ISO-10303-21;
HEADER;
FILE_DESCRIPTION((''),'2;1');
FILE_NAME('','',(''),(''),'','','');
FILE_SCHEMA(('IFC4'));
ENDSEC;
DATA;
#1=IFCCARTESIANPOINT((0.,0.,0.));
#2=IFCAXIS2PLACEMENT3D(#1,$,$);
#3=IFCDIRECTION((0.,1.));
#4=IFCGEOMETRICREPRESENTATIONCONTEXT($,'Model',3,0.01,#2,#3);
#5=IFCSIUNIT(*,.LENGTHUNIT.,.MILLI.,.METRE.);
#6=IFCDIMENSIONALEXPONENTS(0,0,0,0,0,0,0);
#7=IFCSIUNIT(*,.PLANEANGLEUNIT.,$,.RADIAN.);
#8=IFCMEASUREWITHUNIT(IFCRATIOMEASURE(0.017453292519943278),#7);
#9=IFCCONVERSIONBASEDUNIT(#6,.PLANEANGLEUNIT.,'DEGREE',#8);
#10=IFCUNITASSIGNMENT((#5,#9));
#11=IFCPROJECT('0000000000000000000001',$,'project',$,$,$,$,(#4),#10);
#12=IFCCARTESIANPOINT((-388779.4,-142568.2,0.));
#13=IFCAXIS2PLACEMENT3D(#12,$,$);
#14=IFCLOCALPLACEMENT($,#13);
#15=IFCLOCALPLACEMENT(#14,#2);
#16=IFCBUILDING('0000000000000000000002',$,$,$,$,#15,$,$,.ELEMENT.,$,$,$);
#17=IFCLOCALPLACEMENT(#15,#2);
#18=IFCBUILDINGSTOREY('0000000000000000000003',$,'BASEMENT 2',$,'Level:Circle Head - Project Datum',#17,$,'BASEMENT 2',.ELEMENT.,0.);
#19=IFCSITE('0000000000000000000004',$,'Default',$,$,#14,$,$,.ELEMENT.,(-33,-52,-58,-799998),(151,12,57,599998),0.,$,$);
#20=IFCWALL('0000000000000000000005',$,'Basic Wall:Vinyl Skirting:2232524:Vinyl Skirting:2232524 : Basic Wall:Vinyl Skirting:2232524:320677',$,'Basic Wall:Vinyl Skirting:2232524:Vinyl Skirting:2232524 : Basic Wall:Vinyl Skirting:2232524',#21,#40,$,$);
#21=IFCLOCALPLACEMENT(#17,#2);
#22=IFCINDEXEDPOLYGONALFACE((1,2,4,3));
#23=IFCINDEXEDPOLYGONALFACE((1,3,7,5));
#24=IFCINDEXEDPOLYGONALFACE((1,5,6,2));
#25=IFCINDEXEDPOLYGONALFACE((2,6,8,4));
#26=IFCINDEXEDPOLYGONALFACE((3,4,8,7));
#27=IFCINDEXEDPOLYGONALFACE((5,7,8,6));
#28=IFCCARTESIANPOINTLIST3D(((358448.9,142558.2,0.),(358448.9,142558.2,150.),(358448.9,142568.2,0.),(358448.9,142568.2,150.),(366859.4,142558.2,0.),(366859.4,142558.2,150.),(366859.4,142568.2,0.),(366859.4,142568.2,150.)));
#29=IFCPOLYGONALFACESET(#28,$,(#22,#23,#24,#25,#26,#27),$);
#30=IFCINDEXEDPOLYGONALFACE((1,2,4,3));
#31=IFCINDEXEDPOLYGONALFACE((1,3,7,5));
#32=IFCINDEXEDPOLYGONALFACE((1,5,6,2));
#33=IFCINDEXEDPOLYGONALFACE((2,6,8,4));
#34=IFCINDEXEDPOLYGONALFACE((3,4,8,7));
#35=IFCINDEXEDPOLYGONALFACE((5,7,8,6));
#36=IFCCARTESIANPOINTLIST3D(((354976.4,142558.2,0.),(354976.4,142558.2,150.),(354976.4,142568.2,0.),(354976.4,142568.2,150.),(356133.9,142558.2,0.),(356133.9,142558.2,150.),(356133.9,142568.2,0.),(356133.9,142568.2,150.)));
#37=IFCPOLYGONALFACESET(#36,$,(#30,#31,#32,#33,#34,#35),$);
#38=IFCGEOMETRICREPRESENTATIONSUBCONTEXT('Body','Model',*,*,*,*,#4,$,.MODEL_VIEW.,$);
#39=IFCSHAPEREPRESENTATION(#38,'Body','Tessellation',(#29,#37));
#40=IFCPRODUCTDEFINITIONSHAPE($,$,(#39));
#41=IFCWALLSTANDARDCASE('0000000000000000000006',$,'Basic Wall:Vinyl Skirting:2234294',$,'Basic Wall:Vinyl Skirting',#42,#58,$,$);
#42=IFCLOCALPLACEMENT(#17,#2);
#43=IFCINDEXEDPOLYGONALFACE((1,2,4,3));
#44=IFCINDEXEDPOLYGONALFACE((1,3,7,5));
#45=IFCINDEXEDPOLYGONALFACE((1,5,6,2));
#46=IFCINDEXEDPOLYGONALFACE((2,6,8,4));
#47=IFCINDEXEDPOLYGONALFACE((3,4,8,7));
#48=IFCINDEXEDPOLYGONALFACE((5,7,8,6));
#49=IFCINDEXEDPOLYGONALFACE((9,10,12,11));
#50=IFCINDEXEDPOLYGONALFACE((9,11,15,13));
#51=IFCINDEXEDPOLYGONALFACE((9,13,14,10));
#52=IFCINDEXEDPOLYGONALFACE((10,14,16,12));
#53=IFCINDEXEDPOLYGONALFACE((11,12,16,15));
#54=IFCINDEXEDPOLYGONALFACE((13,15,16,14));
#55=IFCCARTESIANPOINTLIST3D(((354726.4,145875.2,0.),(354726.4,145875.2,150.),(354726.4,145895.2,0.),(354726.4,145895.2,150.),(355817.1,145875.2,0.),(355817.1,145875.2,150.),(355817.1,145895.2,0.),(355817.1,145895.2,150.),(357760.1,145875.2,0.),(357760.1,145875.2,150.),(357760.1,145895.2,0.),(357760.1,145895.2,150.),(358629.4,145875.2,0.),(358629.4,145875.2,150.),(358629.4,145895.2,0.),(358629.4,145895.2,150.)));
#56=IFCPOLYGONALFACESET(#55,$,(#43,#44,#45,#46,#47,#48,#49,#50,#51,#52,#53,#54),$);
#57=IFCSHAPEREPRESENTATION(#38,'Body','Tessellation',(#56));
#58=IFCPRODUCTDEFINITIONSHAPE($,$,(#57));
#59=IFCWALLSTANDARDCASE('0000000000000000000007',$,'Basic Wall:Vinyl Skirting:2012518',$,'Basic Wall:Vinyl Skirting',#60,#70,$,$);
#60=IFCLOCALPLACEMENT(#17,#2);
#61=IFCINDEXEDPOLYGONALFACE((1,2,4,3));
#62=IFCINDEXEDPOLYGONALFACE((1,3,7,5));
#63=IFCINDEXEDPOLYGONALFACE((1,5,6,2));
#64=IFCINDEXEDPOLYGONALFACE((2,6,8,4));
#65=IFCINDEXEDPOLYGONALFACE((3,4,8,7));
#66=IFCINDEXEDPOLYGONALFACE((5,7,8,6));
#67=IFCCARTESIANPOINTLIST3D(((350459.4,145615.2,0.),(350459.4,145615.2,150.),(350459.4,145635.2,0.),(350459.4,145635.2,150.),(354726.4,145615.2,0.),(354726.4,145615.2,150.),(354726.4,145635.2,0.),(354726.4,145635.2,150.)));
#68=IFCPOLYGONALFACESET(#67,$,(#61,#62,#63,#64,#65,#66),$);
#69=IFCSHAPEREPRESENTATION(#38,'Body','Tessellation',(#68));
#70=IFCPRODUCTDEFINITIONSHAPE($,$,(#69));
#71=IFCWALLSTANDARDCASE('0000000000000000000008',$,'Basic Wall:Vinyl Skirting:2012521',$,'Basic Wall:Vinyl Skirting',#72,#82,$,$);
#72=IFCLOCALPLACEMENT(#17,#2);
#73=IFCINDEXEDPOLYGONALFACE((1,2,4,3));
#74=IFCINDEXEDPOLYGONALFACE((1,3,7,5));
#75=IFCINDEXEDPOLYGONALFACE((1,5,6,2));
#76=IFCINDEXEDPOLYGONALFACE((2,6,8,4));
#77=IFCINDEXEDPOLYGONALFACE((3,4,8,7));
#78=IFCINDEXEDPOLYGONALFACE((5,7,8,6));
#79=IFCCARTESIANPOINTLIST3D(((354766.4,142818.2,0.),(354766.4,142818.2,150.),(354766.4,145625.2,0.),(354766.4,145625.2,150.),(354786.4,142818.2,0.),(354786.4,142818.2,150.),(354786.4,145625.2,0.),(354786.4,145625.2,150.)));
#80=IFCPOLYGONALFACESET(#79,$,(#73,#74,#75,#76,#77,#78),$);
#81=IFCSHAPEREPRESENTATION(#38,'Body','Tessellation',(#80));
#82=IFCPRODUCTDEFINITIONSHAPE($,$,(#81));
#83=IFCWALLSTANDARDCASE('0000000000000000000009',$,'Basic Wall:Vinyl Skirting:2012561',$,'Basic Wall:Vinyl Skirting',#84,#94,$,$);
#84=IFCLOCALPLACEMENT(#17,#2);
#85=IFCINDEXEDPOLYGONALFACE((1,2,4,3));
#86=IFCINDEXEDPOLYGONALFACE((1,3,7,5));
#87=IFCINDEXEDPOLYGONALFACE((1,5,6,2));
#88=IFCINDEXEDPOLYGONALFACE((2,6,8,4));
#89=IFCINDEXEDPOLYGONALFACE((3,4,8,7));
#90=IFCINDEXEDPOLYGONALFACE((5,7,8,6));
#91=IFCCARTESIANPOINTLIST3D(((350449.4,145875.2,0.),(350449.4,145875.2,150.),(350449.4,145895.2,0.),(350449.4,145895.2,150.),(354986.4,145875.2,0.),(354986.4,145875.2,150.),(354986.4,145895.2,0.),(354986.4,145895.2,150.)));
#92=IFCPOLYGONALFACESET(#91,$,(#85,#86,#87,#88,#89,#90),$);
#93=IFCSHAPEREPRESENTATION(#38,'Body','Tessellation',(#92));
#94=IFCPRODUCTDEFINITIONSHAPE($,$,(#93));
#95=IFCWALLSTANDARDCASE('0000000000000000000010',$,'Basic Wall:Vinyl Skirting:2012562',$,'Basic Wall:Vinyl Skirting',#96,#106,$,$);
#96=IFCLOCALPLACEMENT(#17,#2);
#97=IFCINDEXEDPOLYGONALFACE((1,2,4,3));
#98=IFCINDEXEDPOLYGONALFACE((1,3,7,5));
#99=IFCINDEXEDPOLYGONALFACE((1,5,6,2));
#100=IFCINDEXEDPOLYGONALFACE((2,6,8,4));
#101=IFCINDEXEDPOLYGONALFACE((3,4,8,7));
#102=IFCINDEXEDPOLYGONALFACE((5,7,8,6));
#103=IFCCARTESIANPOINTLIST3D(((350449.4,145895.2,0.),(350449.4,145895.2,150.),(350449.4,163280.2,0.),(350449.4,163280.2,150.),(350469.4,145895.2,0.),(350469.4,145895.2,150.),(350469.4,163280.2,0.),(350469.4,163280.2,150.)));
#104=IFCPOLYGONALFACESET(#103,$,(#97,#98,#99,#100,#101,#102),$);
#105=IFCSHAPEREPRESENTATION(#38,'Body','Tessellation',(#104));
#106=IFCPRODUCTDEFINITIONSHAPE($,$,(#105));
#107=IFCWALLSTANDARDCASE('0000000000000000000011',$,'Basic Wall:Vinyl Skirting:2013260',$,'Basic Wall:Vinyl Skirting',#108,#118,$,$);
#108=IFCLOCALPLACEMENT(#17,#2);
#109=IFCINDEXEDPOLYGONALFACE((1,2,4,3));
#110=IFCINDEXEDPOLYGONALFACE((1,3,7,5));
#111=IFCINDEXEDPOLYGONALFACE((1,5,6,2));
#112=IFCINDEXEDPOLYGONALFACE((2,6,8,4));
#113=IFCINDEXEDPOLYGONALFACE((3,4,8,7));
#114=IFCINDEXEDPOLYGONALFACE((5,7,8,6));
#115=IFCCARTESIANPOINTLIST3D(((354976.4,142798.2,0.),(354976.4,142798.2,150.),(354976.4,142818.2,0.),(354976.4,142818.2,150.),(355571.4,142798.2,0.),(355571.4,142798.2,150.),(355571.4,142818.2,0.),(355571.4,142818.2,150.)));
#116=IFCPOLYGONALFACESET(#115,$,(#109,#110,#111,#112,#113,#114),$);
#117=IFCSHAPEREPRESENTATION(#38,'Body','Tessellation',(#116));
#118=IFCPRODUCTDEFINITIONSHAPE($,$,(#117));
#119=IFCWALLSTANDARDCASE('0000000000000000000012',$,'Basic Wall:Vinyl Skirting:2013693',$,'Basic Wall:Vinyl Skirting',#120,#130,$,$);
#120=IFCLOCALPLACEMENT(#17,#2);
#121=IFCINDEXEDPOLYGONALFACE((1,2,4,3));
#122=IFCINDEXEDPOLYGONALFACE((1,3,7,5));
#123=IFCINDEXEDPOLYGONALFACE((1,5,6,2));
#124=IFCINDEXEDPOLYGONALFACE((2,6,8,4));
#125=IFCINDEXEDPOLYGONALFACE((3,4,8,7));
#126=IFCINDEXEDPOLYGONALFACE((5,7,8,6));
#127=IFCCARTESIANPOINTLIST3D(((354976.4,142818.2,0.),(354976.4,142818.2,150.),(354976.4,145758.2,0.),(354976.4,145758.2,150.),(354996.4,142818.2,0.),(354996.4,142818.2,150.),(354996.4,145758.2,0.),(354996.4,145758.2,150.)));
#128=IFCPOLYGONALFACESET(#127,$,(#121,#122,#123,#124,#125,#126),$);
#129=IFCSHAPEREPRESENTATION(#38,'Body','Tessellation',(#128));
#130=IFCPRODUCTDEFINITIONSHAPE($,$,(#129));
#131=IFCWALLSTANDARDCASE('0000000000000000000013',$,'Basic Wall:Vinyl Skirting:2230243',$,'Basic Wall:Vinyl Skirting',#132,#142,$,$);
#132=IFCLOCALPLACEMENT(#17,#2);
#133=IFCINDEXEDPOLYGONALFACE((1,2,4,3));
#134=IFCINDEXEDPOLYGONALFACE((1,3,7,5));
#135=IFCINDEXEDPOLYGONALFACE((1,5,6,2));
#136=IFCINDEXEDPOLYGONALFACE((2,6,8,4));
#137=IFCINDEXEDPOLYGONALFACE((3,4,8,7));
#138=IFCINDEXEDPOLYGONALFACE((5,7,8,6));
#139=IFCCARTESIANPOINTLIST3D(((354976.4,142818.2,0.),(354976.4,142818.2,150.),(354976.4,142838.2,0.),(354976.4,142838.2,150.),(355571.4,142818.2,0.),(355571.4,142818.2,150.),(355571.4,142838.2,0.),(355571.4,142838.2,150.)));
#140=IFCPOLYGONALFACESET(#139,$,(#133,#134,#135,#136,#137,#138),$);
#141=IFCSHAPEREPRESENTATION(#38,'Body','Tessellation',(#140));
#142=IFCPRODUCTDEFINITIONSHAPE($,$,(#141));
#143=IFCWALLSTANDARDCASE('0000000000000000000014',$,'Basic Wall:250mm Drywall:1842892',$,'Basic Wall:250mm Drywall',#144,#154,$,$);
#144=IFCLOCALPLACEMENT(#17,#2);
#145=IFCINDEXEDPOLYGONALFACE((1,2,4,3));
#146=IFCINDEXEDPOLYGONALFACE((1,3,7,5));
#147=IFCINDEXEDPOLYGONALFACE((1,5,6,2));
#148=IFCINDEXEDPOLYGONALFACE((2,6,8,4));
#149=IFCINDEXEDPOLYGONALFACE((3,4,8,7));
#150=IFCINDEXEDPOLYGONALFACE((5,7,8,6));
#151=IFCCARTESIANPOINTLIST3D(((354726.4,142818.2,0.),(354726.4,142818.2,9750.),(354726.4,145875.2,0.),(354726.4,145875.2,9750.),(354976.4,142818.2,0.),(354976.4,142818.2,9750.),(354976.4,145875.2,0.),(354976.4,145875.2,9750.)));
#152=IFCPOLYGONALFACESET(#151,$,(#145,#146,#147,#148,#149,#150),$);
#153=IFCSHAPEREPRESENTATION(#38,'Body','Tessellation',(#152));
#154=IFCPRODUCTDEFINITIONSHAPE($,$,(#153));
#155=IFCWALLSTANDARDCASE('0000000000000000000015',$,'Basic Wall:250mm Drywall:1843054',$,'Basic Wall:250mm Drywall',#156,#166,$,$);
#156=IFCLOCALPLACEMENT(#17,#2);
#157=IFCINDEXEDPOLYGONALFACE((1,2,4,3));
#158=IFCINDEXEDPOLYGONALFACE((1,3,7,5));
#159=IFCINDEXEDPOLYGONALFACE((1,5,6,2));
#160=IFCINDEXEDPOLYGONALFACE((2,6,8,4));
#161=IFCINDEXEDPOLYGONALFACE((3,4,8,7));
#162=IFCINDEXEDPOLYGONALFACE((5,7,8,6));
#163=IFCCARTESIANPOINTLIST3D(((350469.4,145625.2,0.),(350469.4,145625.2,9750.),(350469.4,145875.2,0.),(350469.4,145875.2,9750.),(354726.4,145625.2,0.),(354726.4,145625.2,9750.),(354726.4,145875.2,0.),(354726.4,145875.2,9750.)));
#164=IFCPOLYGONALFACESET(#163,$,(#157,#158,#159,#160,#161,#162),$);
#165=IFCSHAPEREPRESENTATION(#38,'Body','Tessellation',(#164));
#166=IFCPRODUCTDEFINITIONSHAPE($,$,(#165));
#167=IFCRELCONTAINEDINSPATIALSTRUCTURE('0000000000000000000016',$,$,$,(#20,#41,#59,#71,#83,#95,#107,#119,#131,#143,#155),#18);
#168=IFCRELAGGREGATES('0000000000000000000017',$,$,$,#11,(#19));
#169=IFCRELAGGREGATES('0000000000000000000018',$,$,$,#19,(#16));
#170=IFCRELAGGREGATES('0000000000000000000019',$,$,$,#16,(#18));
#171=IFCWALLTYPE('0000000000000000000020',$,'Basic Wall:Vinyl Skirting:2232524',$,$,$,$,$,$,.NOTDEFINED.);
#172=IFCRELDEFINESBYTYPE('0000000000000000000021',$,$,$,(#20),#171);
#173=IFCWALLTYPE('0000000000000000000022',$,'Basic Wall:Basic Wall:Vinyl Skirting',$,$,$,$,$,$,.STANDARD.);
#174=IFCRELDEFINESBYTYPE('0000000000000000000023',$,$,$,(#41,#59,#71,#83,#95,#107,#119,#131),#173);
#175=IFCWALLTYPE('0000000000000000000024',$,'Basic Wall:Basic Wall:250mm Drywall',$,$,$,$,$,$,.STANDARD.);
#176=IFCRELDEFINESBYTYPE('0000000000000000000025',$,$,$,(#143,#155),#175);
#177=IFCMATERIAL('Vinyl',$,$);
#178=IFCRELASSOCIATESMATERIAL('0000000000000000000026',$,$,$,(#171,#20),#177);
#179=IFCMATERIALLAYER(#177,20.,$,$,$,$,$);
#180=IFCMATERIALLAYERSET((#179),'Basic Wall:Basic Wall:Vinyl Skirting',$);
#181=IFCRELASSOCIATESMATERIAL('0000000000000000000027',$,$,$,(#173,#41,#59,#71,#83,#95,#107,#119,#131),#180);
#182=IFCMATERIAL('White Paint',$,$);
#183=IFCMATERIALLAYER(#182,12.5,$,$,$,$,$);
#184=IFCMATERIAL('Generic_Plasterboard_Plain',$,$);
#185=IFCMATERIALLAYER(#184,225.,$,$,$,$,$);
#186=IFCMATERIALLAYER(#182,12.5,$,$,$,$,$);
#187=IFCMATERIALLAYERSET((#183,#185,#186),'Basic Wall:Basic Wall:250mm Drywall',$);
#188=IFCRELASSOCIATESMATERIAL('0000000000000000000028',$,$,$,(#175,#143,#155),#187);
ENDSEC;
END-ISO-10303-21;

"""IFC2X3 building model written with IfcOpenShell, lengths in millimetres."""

from ifc_helpers import new_model, entity, si_unit, converted_unit, direction, frame, frame_2d, origin, origin_2d_with_axis, place, context, subcontext, project, spatial, rectangle, extrude, material, layer, layer_set, layer_usage, type_object, element, save


model = new_model("IFC2X3")

# Units and contexts
model_context = context("Model", 3, precision=0.01, world=origin(), true_north=direction((0.0, 1.0)))
body_context = subcontext(model_context, "Body", "Model", "MODEL_VIEW")
ifc_project = project(units=[si_unit("LENGTHUNIT", "METRE", prefix="MILLI"), converted_unit("PLANEANGLEUNIT", "DEGREE", entity("IfcRatioMeasure", 0.017453292519943278), si_unit("PLANEANGLEUNIT", "RADIAN"), dimensions=[0, 0, 0, 0, 0, 0, 0])], contexts=[model_context])

# Site, building, storey
site_placement = place(None, frame((-388779.4, -142568.2, 0.0)))
site = spatial("IfcSite", under=ifc_project, at=site_placement, Name="Default", CompositionType="ELEMENT", RefLatitude=(-33, -52, -58, -799998), RefLongitude=(151, 12, 57, 599998), RefElevation=0.0)
building_placement = place(site_placement, origin())
building = spatial("IfcBuilding", under=site, at=building_placement, CompositionType="ELEMENT")
storey_placement = place(building_placement, origin())
storey = spatial("IfcBuildingStorey", under=building, at=storey_placement, Name="BASEMENT 2", ObjectType="Level:Circle Head - Project Datum", LongName="BASEMENT 2", CompositionType="ELEMENT", Elevation=0.0)

# Wall
ifc_material_1 = material(Name="Vinyl")
wall_type_1 = type_object("IfcWallType", Name="Basic Wall:Vinyl Skirting:2232524", PredefinedType="NOTDEFINED", material=ifc_material_1)
wall_1_placement = place(storey_placement, frame((354976.4, 142558.2, 0.0)))
element("IfcWall", 1, at=wall_1_placement, inside=storey, type_object=wall_type_1, material=ifc_material_1, Name="Basic Wall:Vinyl Skirting:2232524:Vinyl Skirting:2232524 : Basic Wall:Vinyl Skirting:2232524:320677", ObjectType="Basic Wall:Vinyl Skirting:2232524:Vinyl Skirting:2232524 : Basic Wall:Vinyl Skirting:2232524", context=body_context, shape_type="SweptSolid", body=[
    extrude(rectangle(XDim=8410.5, YDim=10.0, at=frame_2d((0.0, 0.0), x_axis=(1.0, 0.0))), frame((7677.7, 5.0, 0.0), z_axis=(0.0, 0.0, 1.0), x_axis=(-1.0, 0.0, 0.0)), (0.0, 0.0, 1.0), 150.0),
    extrude(rectangle(XDim=1157.5, YDim=10.0, at=frame_2d((0.0, 0.0), x_axis=(1.0, 0.0))), frame((578.7, 5.0, 0.0), z_axis=(0.0, 0.0, 1.0), x_axis=(-1.0, 0.0, 0.0)), (0.0, 0.0, 1.0), 150.0),
])

# Shared definitions
ifc_layer_1 = layer(ifc_material_1, 20.0)
ifc_layer_set_1 = layer_set([ifc_layer_1], Name="Basic Wall:Basic Wall:Vinyl Skirting")
wall_type_2 = type_object("IfcWallType", Name="Basic Wall:Basic Wall:Vinyl Skirting", PredefinedType="STANDARD", material=ifc_layer_set_1)

# Wall, opening
ifc_layer_usage_1 = layer_usage(ifc_layer_set_1, "AXIS2", "NEGATIVE", 10.0)
wall_2_placement = place(storey_placement, frame((354726.4, 145885.2, 0.0)))
wall_2 = element("IfcWallStandardCase", 2, at=wall_2_placement, inside=storey, type_object=wall_type_2, material=ifc_layer_usage_1, Name="Basic Wall:Vinyl Skirting:2234294", ObjectType="Basic Wall:Vinyl Skirting", context=body_context, shape_type="SweptSolid", body=[
    extrude(rectangle(XDim=3903.0, YDim=20.0, at=frame_2d((1951.5, 0.0), x_axis=(1.0, 0.0))), origin(), (0.0, 0.0, 1.0), 150.0),
])
opening_1_placement = place(wall_2_placement, origin())
element("IfcOpeningElement", 3, at=opening_1_placement, cuts=wall_2, ObjectType="Opening", context=body_context, shape_type="SweptSolid", body=[
    extrude(rectangle(XDim=2082.0, YDim=1943.0, at=origin_2d_with_axis()), frame((2062.2, -10.0, 1041.0), z_axis=(0.0, 1.0, 0.0), x_axis=(0.0, 0.0, -1.0)), (0.0, 0.0, 1.0), 20.0),
])

# Walls
ifc_layer_usage_2 = layer_usage(ifc_layer_set_1, "AXIS2", "NEGATIVE", 10.0)
wall_3_placement = place(storey_placement, frame((350459.4, 145625.2, 0.0)))
element("IfcWallStandardCase", 4, at=wall_3_placement, inside=storey, type_object=wall_type_2, material=ifc_layer_usage_2, Name="Basic Wall:Vinyl Skirting:2012518", ObjectType="Basic Wall:Vinyl Skirting", context=body_context, shape_type="SweptSolid", body=[
    extrude(rectangle(XDim=4267.0, YDim=20.0, at=frame_2d((2133.5, 0.0), x_axis=(-1.0, 0.0))), origin(), (0.0, 0.0, 1.0), 150.0),
])
ifc_layer_usage_3 = layer_usage(ifc_layer_set_1, "AXIS2", "NEGATIVE", 10.0)
wall_4_placement = place(storey_placement, frame((354776.4, 145625.2, 0.0), z_axis=(0.0, 0.0, 1.0), x_axis=(0.0, -1.0, 0.0)))
element("IfcWallStandardCase", 5, at=wall_4_placement, inside=storey, type_object=wall_type_2, material=ifc_layer_usage_3, Name="Basic Wall:Vinyl Skirting:2012521", ObjectType="Basic Wall:Vinyl Skirting", context=body_context, shape_type="SweptSolid", body=[
    extrude(rectangle(XDim=2807.0, YDim=20.0, at=frame_2d((1403.5, 0.0), x_axis=(-1.0, 0.0))), origin(), (0.0, 0.0, 1.0), 150.0),
])
ifc_layer_usage_4 = layer_usage(ifc_layer_set_1, "AXIS2", "NEGATIVE", 10.0)
wall_5_placement = place(storey_placement, frame((350449.4, 145885.2, 0.0)))
element("IfcWallStandardCase", 6, at=wall_5_placement, inside=storey, type_object=wall_type_2, material=ifc_layer_usage_4, Name="Basic Wall:Vinyl Skirting:2012561", ObjectType="Basic Wall:Vinyl Skirting", context=body_context, shape_type="SweptSolid", body=[
    extrude(rectangle(XDim=4537.0, YDim=20.0, at=frame_2d((2268.5, 0.0), x_axis=(-1.0, 0.0))), origin(), (0.0, 0.0, 1.0), 150.0),
])
ifc_layer_usage_5 = layer_usage(ifc_layer_set_1, "AXIS2", "NEGATIVE", 10.0)
wall_6_placement = place(storey_placement, frame((350459.4, 163280.2, 0.0), z_axis=(0.0, 0.0, 1.0), x_axis=(0.0, -1.0, 0.0)))
element("IfcWallStandardCase", 7, at=wall_6_placement, inside=storey, type_object=wall_type_2, material=ifc_layer_usage_5, Name="Basic Wall:Vinyl Skirting:2012562", ObjectType="Basic Wall:Vinyl Skirting", context=body_context, shape_type="SweptSolid", body=[
    extrude(rectangle(XDim=17385.0, YDim=20.0, at=frame_2d((8692.5, 0.0), x_axis=(-1.0, 0.0))), origin(), (0.0, 0.0, 1.0), 150.0),
])
ifc_layer_usage_6 = layer_usage(ifc_layer_set_1, "AXIS2", "NEGATIVE", 10.0)
wall_7_placement = place(storey_placement, frame((354976.4, 142808.2, 0.0)))
element("IfcWallStandardCase", 8, at=wall_7_placement, inside=storey, type_object=wall_type_2, material=ifc_layer_usage_6, Name="Basic Wall:Vinyl Skirting:2013260", ObjectType="Basic Wall:Vinyl Skirting", context=body_context, shape_type="SweptSolid", body=[
    extrude(rectangle(XDim=595.0, YDim=20.0, at=frame_2d((297.5, 0.0), x_axis=(-1.0, 0.0))), origin(), (0.0, 0.0, 1.0), 150.0),
])
ifc_layer_usage_7 = layer_usage(ifc_layer_set_1, "AXIS2", "NEGATIVE", 10.0)
wall_8_placement = place(storey_placement, frame((354986.4, 142818.2, 0.0), z_axis=(0.0, 0.0, 1.0), x_axis=(0.0, 1.0, 0.0)))
element("IfcWallStandardCase", 9, at=wall_8_placement, inside=storey, type_object=wall_type_2, material=ifc_layer_usage_7, Name="Basic Wall:Vinyl Skirting:2013693", ObjectType="Basic Wall:Vinyl Skirting", context=body_context, shape_type="SweptSolid", body=[
    extrude(rectangle(XDim=2940.0, YDim=20.0, at=frame_2d((1470.0, 0.0), x_axis=(-1.0, 0.0))), origin(), (0.0, 0.0, 1.0), 150.0),
])
ifc_layer_usage_8 = layer_usage(ifc_layer_set_1, "AXIS2", "NEGATIVE", 10.0)
wall_9_placement = place(storey_placement, frame((354976.4, 142828.2, 0.0)))
element("IfcWallStandardCase", 10, at=wall_9_placement, inside=storey, type_object=wall_type_2, material=ifc_layer_usage_8, Name="Basic Wall:Vinyl Skirting:2230243", ObjectType="Basic Wall:Vinyl Skirting", context=body_context, shape_type="SweptSolid", body=[
    extrude(rectangle(XDim=595.0, YDim=20.0, at=frame_2d((297.5, 0.0), x_axis=(-1.0, 0.0))), origin(), (0.0, 0.0, 1.0), 150.0),
])

# Shared definitions
ifc_material_2 = material(Name="White Paint")
ifc_layer_2 = layer(ifc_material_2, 12.5)
ifc_material_3 = material(Name="Generic_Plasterboard_Plain")
ifc_layer_3 = layer(ifc_material_3, 225.0)
ifc_layer_4 = layer(ifc_material_2, 12.5)
ifc_layer_set_2 = layer_set([ifc_layer_2, ifc_layer_3, ifc_layer_4], Name="Basic Wall:Basic Wall:250mm Drywall")
wall_type_3 = type_object("IfcWallType", Name="Basic Wall:Basic Wall:250mm Drywall", PredefinedType="STANDARD", material=ifc_layer_set_2)

# Walls
ifc_layer_usage_9 = layer_usage(ifc_layer_set_2, "AXIS2", "NEGATIVE", 125.0)
wall_10_placement = place(storey_placement, frame((354851.4, 142818.2, 0.0), z_axis=(0.0, 0.0, 1.0), x_axis=(0.0, 1.0, 0.0)))
element("IfcWallStandardCase", 11, at=wall_10_placement, inside=storey, type_object=wall_type_3, material=ifc_layer_usage_9, Name="Basic Wall:250mm Drywall:1842892", ObjectType="Basic Wall:250mm Drywall", context=body_context, shape_type="SweptSolid", body=[
    extrude(rectangle(XDim=3057.0, YDim=250.0, at=frame_2d((1528.5, 0.0), x_axis=(-1.0, 0.0))), origin(), (0.0, 0.0, 1.0), 9750.0),
])
ifc_layer_usage_10 = layer_usage(ifc_layer_set_2, "AXIS2", "NEGATIVE", 125.0)
wall_11_placement = place(storey_placement, frame((354726.4, 145750.2, 0.0), z_axis=(0.0, 0.0, 1.0), x_axis=(-1.0, 0.0, 0.0)))
element("IfcWallStandardCase", 12, at=wall_11_placement, inside=storey, type_object=wall_type_3, material=ifc_layer_usage_10, Name="Basic Wall:250mm Drywall:1843054", ObjectType="Basic Wall:250mm Drywall", context=body_context, shape_type="SweptSolid", body=[
    extrude(rectangle(XDim=4257.0, YDim=250.0, at=frame_2d((2128.5, 0.0), x_axis=(-1.0, 0.0))), origin(), (0.0, 0.0, 1.0), 9750.0),
])

save(model, "model.ifc")
